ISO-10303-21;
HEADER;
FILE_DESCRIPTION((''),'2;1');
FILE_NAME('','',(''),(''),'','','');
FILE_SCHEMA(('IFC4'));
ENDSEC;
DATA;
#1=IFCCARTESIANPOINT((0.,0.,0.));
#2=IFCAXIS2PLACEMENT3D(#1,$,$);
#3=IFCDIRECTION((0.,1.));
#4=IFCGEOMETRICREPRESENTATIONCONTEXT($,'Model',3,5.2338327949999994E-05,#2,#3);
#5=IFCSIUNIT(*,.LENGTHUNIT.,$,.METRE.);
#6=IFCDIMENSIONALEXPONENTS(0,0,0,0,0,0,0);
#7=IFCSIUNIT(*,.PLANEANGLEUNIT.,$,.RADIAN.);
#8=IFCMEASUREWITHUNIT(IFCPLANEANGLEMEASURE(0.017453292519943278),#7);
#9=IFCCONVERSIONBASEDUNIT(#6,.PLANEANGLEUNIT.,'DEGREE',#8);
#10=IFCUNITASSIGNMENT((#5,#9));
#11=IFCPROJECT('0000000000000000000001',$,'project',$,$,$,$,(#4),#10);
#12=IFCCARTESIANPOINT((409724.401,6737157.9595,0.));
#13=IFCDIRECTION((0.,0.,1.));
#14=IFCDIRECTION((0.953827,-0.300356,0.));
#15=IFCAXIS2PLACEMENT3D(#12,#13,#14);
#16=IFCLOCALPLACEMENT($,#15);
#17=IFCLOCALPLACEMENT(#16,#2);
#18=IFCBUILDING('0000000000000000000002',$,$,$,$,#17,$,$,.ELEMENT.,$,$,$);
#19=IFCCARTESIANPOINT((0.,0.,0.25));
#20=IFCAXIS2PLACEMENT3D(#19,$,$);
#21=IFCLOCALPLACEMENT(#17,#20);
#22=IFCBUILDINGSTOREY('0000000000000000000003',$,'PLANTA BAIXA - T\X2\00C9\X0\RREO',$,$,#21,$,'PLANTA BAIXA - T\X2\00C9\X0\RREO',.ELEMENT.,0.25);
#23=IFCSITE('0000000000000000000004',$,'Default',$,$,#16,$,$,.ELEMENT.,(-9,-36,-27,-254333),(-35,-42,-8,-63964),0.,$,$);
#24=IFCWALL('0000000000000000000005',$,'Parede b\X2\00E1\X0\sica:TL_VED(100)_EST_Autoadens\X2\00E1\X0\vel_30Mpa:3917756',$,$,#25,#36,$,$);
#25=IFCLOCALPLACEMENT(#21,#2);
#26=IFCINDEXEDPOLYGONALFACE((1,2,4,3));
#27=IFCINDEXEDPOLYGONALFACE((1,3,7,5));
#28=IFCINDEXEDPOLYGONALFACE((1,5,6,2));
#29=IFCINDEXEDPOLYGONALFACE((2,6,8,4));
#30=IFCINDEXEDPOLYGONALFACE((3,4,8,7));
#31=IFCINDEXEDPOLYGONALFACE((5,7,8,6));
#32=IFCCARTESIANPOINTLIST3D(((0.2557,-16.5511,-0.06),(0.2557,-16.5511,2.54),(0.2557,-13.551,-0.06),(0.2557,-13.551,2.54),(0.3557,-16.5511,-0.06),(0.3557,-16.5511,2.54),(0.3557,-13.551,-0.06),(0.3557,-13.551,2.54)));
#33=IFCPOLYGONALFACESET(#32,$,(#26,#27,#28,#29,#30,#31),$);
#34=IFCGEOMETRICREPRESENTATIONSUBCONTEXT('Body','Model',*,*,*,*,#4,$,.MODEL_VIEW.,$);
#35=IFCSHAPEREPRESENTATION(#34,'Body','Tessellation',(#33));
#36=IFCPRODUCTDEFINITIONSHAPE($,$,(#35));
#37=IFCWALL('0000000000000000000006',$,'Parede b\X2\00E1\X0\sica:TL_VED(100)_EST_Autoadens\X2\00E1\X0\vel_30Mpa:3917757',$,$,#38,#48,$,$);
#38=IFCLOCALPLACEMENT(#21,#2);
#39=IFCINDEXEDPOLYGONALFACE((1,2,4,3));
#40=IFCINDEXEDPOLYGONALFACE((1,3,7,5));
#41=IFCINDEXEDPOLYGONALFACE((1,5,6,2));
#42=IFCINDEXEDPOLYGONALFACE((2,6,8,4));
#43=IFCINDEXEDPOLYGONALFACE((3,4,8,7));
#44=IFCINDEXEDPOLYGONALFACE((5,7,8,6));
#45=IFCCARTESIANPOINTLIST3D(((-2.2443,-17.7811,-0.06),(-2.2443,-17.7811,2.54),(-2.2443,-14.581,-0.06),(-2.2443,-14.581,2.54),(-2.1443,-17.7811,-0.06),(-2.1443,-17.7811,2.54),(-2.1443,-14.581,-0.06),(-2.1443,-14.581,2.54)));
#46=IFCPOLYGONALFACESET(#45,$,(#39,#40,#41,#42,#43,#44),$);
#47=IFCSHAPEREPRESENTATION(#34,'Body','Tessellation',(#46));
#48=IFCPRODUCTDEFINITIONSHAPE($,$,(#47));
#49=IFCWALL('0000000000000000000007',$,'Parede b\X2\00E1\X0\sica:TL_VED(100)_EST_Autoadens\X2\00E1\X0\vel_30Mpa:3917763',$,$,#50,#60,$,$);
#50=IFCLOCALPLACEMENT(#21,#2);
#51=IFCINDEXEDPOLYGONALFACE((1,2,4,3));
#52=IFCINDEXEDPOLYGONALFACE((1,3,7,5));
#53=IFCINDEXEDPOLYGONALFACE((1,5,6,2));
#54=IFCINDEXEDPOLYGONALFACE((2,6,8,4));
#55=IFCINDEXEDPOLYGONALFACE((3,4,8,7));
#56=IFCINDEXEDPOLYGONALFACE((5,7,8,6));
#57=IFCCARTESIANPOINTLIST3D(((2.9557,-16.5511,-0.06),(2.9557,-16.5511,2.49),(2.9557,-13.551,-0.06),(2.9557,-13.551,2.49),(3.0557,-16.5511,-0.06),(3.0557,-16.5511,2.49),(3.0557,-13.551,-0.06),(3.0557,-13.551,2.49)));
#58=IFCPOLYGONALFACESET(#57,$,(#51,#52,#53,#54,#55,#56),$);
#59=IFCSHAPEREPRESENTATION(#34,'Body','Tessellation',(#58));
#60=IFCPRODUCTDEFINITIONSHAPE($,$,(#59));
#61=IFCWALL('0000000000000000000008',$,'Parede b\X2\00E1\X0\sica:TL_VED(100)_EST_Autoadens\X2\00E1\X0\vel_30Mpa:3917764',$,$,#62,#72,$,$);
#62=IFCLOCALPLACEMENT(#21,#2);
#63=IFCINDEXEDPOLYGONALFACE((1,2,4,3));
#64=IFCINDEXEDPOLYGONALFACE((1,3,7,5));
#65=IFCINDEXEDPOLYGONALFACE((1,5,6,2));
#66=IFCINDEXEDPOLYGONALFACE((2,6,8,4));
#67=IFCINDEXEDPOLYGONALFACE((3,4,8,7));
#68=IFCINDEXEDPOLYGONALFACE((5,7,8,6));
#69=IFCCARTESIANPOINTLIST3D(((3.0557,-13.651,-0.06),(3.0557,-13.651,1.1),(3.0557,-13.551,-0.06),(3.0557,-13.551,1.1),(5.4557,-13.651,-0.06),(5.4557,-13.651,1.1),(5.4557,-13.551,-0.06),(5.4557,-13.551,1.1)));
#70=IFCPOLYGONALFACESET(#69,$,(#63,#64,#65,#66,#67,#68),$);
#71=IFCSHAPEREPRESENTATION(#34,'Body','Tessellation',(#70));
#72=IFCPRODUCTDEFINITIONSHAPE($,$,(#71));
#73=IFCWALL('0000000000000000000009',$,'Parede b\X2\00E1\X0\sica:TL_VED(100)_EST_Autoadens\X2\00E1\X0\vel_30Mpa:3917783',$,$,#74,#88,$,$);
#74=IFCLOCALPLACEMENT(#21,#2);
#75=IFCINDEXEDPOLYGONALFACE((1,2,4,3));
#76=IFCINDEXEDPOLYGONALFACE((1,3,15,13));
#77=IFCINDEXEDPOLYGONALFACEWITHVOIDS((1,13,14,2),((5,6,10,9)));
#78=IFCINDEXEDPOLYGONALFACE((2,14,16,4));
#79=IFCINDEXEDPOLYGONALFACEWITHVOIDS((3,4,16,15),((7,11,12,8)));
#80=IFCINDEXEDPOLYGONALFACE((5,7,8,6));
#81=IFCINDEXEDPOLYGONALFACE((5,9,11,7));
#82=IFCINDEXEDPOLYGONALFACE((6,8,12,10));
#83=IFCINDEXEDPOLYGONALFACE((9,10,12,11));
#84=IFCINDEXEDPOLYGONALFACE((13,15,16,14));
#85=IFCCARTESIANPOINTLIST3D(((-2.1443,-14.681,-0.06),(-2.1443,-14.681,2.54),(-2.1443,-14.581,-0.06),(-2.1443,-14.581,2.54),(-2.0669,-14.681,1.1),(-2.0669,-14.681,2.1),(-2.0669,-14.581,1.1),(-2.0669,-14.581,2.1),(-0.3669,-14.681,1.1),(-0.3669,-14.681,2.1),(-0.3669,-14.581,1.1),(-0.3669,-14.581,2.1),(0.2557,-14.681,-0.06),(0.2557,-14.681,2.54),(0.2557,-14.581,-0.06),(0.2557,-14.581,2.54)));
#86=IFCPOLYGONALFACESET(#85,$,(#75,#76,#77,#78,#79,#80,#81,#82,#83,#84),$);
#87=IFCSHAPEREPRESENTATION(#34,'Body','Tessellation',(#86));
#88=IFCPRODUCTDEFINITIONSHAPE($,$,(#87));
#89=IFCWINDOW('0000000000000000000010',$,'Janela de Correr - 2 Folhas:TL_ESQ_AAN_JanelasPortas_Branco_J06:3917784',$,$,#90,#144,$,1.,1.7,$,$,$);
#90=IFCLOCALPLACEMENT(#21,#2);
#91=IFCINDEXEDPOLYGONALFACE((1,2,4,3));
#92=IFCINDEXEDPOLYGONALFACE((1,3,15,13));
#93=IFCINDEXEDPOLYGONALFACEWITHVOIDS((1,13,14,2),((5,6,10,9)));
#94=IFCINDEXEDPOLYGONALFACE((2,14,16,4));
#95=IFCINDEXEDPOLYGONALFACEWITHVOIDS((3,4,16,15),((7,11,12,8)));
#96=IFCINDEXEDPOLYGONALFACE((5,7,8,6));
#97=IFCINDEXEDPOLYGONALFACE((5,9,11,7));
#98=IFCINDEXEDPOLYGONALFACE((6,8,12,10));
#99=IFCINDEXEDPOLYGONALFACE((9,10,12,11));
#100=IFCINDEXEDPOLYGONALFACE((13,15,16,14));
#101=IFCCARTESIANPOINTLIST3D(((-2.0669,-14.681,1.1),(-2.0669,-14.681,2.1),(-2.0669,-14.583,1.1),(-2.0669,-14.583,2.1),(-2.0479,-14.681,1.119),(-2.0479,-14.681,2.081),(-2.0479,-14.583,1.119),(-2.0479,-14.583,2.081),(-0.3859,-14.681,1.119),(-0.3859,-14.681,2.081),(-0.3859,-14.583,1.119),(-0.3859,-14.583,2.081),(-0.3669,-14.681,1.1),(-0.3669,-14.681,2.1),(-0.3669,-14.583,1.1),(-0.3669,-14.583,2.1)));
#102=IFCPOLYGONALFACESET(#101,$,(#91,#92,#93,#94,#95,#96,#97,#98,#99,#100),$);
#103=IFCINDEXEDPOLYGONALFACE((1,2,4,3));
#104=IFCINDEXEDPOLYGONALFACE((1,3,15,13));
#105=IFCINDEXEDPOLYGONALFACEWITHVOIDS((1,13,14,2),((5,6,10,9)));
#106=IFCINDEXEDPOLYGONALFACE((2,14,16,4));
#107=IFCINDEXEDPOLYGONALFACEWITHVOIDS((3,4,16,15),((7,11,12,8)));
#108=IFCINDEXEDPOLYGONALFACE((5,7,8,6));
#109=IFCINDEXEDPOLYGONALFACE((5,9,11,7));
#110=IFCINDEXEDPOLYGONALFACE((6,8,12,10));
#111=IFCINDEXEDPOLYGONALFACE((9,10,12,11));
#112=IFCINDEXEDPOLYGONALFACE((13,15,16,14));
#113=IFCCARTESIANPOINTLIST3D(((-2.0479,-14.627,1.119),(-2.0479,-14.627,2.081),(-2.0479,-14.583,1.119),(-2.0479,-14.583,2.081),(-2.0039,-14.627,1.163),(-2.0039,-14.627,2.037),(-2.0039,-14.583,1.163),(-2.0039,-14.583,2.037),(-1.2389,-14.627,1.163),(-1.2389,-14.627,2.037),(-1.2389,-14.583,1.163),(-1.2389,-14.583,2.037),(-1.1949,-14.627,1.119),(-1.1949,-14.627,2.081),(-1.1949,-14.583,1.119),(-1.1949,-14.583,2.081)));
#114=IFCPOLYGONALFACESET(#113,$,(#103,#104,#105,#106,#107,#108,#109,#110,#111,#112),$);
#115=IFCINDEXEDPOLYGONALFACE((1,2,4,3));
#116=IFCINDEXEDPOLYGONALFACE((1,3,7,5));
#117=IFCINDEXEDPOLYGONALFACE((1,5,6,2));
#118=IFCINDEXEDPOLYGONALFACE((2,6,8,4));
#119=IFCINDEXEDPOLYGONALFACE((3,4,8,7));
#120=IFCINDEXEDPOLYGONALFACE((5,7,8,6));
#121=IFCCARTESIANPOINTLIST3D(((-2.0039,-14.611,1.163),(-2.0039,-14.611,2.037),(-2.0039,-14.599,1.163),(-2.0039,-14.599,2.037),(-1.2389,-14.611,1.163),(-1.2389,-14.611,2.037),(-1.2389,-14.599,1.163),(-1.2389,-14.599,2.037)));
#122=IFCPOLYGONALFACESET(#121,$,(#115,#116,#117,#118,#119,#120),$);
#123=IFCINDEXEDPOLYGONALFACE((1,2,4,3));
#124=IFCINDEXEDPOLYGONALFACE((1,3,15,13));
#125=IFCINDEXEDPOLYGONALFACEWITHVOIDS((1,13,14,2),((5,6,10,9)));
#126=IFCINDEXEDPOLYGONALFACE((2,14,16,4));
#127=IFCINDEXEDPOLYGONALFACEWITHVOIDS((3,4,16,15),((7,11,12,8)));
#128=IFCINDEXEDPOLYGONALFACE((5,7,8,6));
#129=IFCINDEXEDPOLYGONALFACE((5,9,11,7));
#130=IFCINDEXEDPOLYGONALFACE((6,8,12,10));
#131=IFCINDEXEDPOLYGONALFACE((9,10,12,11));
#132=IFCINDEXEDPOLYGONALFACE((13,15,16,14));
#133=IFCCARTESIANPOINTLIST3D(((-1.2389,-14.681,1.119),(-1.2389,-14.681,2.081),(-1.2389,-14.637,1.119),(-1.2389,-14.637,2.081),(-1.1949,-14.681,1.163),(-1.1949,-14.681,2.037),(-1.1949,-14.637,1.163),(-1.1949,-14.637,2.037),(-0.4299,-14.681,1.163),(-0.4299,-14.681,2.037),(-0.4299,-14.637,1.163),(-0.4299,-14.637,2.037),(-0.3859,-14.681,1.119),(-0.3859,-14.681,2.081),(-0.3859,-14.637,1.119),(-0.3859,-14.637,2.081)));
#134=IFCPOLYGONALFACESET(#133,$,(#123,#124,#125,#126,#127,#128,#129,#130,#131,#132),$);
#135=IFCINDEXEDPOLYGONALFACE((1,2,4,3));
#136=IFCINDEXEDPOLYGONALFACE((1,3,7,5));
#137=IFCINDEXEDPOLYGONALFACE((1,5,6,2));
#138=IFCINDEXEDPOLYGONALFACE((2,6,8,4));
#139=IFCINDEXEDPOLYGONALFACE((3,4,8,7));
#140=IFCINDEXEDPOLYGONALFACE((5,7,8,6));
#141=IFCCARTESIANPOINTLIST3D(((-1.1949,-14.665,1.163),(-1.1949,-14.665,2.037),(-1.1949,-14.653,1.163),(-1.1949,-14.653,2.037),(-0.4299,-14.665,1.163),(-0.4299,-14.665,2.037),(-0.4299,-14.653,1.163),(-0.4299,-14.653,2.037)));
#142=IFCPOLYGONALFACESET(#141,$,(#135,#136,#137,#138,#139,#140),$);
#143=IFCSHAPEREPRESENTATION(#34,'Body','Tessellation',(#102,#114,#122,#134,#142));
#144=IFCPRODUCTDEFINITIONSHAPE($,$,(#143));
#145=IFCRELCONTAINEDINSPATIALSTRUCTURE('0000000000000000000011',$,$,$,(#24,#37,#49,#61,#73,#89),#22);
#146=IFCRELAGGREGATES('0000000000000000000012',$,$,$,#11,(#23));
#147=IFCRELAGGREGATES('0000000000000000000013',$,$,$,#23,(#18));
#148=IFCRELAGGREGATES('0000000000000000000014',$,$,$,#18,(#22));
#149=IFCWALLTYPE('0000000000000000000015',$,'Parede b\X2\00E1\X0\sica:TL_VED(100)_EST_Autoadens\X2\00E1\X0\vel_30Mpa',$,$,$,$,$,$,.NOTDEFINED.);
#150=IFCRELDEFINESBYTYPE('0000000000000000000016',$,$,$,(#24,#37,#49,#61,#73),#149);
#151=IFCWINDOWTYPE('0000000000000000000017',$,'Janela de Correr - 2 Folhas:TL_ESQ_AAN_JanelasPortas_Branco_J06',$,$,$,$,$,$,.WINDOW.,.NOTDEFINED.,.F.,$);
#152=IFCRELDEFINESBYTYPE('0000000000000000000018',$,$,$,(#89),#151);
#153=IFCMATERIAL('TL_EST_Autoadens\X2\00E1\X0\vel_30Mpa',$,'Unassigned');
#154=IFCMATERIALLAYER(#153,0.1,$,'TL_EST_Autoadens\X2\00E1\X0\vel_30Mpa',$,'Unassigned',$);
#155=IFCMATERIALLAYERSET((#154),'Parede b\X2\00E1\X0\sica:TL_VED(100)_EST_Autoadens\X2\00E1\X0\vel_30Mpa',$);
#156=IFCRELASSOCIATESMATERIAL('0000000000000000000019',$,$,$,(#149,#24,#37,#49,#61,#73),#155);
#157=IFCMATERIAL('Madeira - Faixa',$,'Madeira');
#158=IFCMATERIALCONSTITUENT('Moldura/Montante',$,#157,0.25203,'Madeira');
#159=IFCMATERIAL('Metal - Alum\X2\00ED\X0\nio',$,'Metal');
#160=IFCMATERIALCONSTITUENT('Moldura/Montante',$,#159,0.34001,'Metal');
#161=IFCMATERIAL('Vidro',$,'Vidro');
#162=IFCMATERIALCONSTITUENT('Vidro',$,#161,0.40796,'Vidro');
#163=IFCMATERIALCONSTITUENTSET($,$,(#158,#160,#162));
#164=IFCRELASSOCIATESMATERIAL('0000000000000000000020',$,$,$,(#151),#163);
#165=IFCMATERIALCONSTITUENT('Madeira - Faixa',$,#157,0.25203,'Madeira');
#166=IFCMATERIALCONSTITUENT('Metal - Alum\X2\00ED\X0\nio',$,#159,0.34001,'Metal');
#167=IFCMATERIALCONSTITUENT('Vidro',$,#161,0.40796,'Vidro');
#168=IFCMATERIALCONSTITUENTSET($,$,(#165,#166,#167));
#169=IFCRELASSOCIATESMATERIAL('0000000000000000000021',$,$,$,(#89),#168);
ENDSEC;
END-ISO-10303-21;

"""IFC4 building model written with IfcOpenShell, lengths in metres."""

from ifc_helpers import new_model, entity, si_unit, converted_unit, direction, frame, frame_2d, origin, origin_2d_with_axis, place, context, subcontext, project, spatial, polyline, rectangle, outline, extrude, source, transform, mapped, material, layer, layer_set, layer_usage, constituent, constituent_set, type_object, type_shapes, element, fill, save


model = new_model("IFC4")

# Units and contexts
model_context = context("Model", 3, precision=5.2338327949999994e-05, world=origin(), true_north=direction((0.0, 1.0)))
body_context = subcontext(model_context, "Body", "Model", "MODEL_VIEW")
ifc_project = project(units=[si_unit("LENGTHUNIT", "METRE"), converted_unit("PLANEANGLEUNIT", "DEGREE", entity("IfcPlaneAngleMeasure", 0.017453292519943278), si_unit("PLANEANGLEUNIT", "RADIAN"), dimensions=[0, 0, 0, 0, 0, 0, 0])], contexts=[model_context])

# Site, building, storey
site_placement = place(None, frame((409724.401, 6737157.9595, 0.0), z_axis=(0.0, 0.0, 1.0), x_axis=(0.953827, -0.300356, 0.0)))
site = spatial("IfcSite", under=ifc_project, at=site_placement, Name="Default", CompositionType="ELEMENT", RefLatitude=(-9, -36, -27, -254333), RefLongitude=(-35, -42, -8, -63964), RefElevation=0.0)
building_placement = place(site_placement, origin())
building = spatial("IfcBuilding", under=site, at=building_placement, CompositionType="ELEMENT")
storey_placement = place(building_placement, frame((0.0, 0.0, 0.25)))
storey = spatial("IfcBuildingStorey", under=building, at=storey_placement, Name="PLANTA BAIXA - TÉRREO", LongName="PLANTA BAIXA - TÉRREO", CompositionType="ELEMENT", Elevation=0.25)

# Walls
ifc_material_1 = material(Name="TL_EST_Autoadensável_30Mpa", Category="Unassigned")
ifc_layer_1 = layer(ifc_material_1, 0.1, Name="TL_EST_Autoadensável_30Mpa", Category="Unassigned")
ifc_layer_set_1 = layer_set([ifc_layer_1], Name="Parede básica:TL_VED(100)_EST_Autoadensável_30Mpa")
ifc_layer_usage_1 = layer_usage(ifc_layer_set_1, "AXIS2", "NEGATIVE", 0.05)
wall_type_1 = type_object("IfcWallType", Name="Parede básica:TL_VED(100)_EST_Autoadensável_30Mpa", PredefinedType="NOTDEFINED", material=ifc_layer_set_1)
wall_1_placement = place(storey_placement, frame((0.3057, -13.551, -0.06), z_axis=(0.0, 0.0, 1.0), x_axis=(0.0, -1.0, 0.0)))
element("IfcWall", 1, at=wall_1_placement, inside=storey, type_object=wall_type_1, material=ifc_layer_usage_1, Name="Parede básica:TL_VED(100)_EST_Autoadensável_30Mpa:3917756", context=body_context, shape_type="SweptSolid", body=[
    extrude(rectangle(XDim=3.0001, YDim=0.1, at=frame_2d((1.5001, 0.0), x_axis=(-1.0, 0.0))), origin(), (0.0, 0.0, 1.0), 2.6),
])
ifc_layer_usage_2 = layer_usage(ifc_layer_set_1, "AXIS2", "NEGATIVE", 0.05)
wall_2_placement = place(storey_placement, frame((-2.1943, -14.581, -0.06), z_axis=(0.0, 0.0, 1.0), x_axis=(0.0, -1.0, 0.0)))
element("IfcWall", 2, at=wall_2_placement, inside=storey, type_object=wall_type_1, material=ifc_layer_usage_2, Name="Parede básica:TL_VED(100)_EST_Autoadensável_30Mpa:3917757", context=body_context, shape_type="SweptSolid", body=[
    extrude(rectangle(XDim=3.2001, YDim=0.1, at=frame_2d((1.6001, 0.0), x_axis=(-1.0, 0.0))), origin(), (0.0, 0.0, 1.0), 2.6),
])

# Wall, opening
ifc_layer_usage_3 = layer_usage(ifc_layer_set_1, "AXIS2", "NEGATIVE", 0.05)
wall_3_placement = place(storey_placement, frame((3.0057, -13.551, -0.06), z_axis=(0.0, 0.0, 1.0), x_axis=(0.0, -1.0, 0.0)))
wall_3 = element("IfcWall", 3, at=wall_3_placement, inside=storey, type_object=wall_type_1, material=ifc_layer_usage_3, Name="Parede básica:TL_VED(100)_EST_Autoadensável_30Mpa:3917763", context=body_context, shape_type="SweptSolid", body=[
    extrude(rectangle(XDim=3.0001, YDim=0.1, at=frame_2d((1.5001, 0.0), x_axis=(-1.0, 0.0))), origin(), (0.0, 0.0, 1.0), 2.55),
])
opening_1_placement = place(wall_3_placement, frame((-13.551, -3.0057, 0.06)))
element("IfcOpeningElement", 4, at=opening_1_placement, cuts=wall_3, PredefinedType="OPENING", context=body_context, shape_type="SweptSolid", body=[
    extrude(rectangle(XDim=2.1, YDim=0.1, at=frame_2d((0.0, 0.0), x_axis=(0.0, 1.0))), frame((14.501, 3.0557, 1.05), z_axis=(0.0, 1.0, 0.0), x_axis=(1.0, 0.0, 0.0)), (0.0, 0.0, 1.0), 2.4),
])

# Wall
ifc_layer_usage_4 = layer_usage(ifc_layer_set_1, "AXIS2", "NEGATIVE", 0.05)
wall_4_placement = place(storey_placement, frame((3.0557, -13.601, -0.06)))
element("IfcWall", 5, at=wall_4_placement, inside=storey, type_object=wall_type_1, material=ifc_layer_usage_4, Name="Parede básica:TL_VED(100)_EST_Autoadensável_30Mpa:3917764", context=body_context, shape_type="SweptSolid", body=[
    extrude(rectangle(XDim=2.4, YDim=0.1, at=frame_2d((1.2, 0.0), x_axis=(-1.0, 0.0))), origin(), (0.0, 0.0, 1.0), 1.16),
])

# Wall, opening, window
ifc_layer_usage_5 = layer_usage(ifc_layer_set_1, "AXIS2", "NEGATIVE", 0.05)
wall_5_placement = place(storey_placement, frame((-2.1443, -14.631, -0.06)))
wall_5 = element("IfcWall", 6, at=wall_5_placement, inside=storey, type_object=wall_type_1, material=ifc_layer_usage_5, Name="Parede básica:TL_VED(100)_EST_Autoadensável_30Mpa:3917783", context=body_context, shape_type="SweptSolid", body=[
    extrude(rectangle(XDim=2.4, YDim=0.1, at=frame_2d((1.2, 0.0), x_axis=(-1.0, 0.0))), origin(), (0.0, 0.0, 1.0), 2.6),
])
opening_2_placement = place(wall_5_placement, frame((0.0774, -0.05, 1.16)))
opening_2 = element("IfcOpeningElement", 7, at=opening_2_placement, cuts=wall_5, PredefinedType="OPENING", context=body_context, shape_type="SweptSolid", body=[
    extrude(rectangle(XDim=1.0, YDim=1.7, at=frame_2d((0.5, 0.85), x_axis=(-1.0, 0.0))), frame((0.0, 0.0, 0.0), z_axis=(0.0, 1.0, 0.0), x_axis=(0.0, 0.0, 1.0)), (0.0, 0.0, 1.0), 0.1),
])
ifc_material_2 = material(Name="Madeira - Faixa", Category="Madeira")
ifc_constituent_1 = constituent(ifc_material_2, Name="Madeira - Faixa", Category="Madeira", fraction=0.25203)
ifc_material_3 = material(Name="Metal - Alumínio", Category="Metal")
ifc_constituent_2 = constituent(ifc_material_3, Name="Metal - Alumínio", Category="Metal", fraction=0.34001)
ifc_material_4 = material(Name="Vidro", Category="Vidro")
ifc_constituent_3 = constituent(ifc_material_4, Name="Vidro", Category="Vidro", fraction=0.40796)
ifc_constituent_set_1 = constituent_set(constituents=[ifc_constituent_1, ifc_constituent_2, ifc_constituent_3])
ifc_constituent_4 = constituent(ifc_material_2, Name="Moldura/Montante", Category="Madeira", fraction=0.25203)
ifc_constituent_5 = constituent(ifc_material_3, Name="Moldura/Montante", Category="Metal", fraction=0.34001)
ifc_constituent_6 = constituent(ifc_material_4, Name="Vidro", Category="Vidro", fraction=0.40796)
ifc_constituent_set_2 = constituent_set(constituents=[ifc_constituent_4, ifc_constituent_5, ifc_constituent_6])
window_type_1 = type_object("IfcWindowType", Name="Janela de Correr - 2 Folhas:TL_ESQ_AAN_JanelasPortas_Branco_J06", ParameterTakesPrecedence=False, PartitioningType="NOTDEFINED", PredefinedType="WINDOW", material=ifc_constituent_set_2)
shared_shape_1 = source(origin(), body_context, "Body", "SweptSolid", [
    extrude(outline(polyline([(-0.85, -0.5), (0.85, -0.5), (0.85, 0.5), (-0.85, 0.5), (-0.85, -0.5)]), holes=[polyline([(-0.831, -0.481), (-0.831, 0.481), (0.831, 0.481), (0.831, -0.481), (-0.831, -0.481)])]), frame((0.85, 0.124, 0.5), z_axis=(0.0, -1.0, 0.0), x_axis=(-1.0, 0.0, 0.0)), (0.0, 0.0, 1.0), 0.098),
    extrude(outline(polyline([(-0.4265, -0.481), (0.4265, -0.481), (0.4265, 0.481), (-0.4265, 0.481), (-0.4265, -0.481)]), holes=[polyline([(-0.3825, -0.437), (-0.3825, 0.437), (0.3825, 0.437), (0.3825, -0.437), (-0.3825, -0.437)])]), frame((0.4455, 0.124, 0.5), z_axis=(0.0, -1.0, 0.0), x_axis=(-1.0, 0.0, 0.0)), (0.0, 0.0, 1.0), 0.044),
    extrude(rectangle(XDim=0.765, YDim=0.012, at=origin_2d_with_axis()), frame((0.4455, 0.102, 0.063), z_axis=(0.0, 0.0, 1.0), x_axis=(-1.0, 0.0, 0.0)), (0.0, 0.0, 1.0), 0.874),
    extrude(outline(polyline([(-0.481, -0.4265), (0.481, -0.4265), (0.481, 0.4265), (-0.481, 0.4265), (-0.481, -0.4265)]), holes=[polyline([(-0.437, -0.3825), (-0.437, 0.3825), (0.437, 0.3825), (0.437, -0.3825), (-0.437, -0.3825)])]), frame((1.2545, 0.07, 0.5), z_axis=(0.0, -1.0, 0.0), x_axis=(0.0, 0.0, -1.0)), (0.0, 0.0, 1.0), 0.044),
    extrude(rectangle(XDim=0.765, YDim=0.012, at=origin_2d_with_axis()), frame((1.2545, 0.048, 0.063), z_axis=(0.0, 0.0, 1.0), x_axis=(-1.0, 0.0, 0.0)), (0.0, 0.0, 1.0), 0.874),
])
type_shapes(window_type_1, [shared_shape_1])
window_1_placement = place(opening_2_placement, frame((0.0, -0.026, 0.0)))
window_1 = element("IfcWindow", 8, at=window_1_placement, inside=storey, type_object=window_type_1, material=ifc_constituent_set_1, Name="Janela de Correr - 2 Folhas:TL_ESQ_AAN_JanelasPortas_Branco_J06:3917784", OverallHeight=1.0, OverallWidth=1.7, context=body_context, shape_type="MappedRepresentation", body=[
    mapped(shared_shape_1, transform((0.0, 0.0, 0.0), scale=1.0)),
])
fill(opening_2, window_1)

save(model, "model.ifc")
